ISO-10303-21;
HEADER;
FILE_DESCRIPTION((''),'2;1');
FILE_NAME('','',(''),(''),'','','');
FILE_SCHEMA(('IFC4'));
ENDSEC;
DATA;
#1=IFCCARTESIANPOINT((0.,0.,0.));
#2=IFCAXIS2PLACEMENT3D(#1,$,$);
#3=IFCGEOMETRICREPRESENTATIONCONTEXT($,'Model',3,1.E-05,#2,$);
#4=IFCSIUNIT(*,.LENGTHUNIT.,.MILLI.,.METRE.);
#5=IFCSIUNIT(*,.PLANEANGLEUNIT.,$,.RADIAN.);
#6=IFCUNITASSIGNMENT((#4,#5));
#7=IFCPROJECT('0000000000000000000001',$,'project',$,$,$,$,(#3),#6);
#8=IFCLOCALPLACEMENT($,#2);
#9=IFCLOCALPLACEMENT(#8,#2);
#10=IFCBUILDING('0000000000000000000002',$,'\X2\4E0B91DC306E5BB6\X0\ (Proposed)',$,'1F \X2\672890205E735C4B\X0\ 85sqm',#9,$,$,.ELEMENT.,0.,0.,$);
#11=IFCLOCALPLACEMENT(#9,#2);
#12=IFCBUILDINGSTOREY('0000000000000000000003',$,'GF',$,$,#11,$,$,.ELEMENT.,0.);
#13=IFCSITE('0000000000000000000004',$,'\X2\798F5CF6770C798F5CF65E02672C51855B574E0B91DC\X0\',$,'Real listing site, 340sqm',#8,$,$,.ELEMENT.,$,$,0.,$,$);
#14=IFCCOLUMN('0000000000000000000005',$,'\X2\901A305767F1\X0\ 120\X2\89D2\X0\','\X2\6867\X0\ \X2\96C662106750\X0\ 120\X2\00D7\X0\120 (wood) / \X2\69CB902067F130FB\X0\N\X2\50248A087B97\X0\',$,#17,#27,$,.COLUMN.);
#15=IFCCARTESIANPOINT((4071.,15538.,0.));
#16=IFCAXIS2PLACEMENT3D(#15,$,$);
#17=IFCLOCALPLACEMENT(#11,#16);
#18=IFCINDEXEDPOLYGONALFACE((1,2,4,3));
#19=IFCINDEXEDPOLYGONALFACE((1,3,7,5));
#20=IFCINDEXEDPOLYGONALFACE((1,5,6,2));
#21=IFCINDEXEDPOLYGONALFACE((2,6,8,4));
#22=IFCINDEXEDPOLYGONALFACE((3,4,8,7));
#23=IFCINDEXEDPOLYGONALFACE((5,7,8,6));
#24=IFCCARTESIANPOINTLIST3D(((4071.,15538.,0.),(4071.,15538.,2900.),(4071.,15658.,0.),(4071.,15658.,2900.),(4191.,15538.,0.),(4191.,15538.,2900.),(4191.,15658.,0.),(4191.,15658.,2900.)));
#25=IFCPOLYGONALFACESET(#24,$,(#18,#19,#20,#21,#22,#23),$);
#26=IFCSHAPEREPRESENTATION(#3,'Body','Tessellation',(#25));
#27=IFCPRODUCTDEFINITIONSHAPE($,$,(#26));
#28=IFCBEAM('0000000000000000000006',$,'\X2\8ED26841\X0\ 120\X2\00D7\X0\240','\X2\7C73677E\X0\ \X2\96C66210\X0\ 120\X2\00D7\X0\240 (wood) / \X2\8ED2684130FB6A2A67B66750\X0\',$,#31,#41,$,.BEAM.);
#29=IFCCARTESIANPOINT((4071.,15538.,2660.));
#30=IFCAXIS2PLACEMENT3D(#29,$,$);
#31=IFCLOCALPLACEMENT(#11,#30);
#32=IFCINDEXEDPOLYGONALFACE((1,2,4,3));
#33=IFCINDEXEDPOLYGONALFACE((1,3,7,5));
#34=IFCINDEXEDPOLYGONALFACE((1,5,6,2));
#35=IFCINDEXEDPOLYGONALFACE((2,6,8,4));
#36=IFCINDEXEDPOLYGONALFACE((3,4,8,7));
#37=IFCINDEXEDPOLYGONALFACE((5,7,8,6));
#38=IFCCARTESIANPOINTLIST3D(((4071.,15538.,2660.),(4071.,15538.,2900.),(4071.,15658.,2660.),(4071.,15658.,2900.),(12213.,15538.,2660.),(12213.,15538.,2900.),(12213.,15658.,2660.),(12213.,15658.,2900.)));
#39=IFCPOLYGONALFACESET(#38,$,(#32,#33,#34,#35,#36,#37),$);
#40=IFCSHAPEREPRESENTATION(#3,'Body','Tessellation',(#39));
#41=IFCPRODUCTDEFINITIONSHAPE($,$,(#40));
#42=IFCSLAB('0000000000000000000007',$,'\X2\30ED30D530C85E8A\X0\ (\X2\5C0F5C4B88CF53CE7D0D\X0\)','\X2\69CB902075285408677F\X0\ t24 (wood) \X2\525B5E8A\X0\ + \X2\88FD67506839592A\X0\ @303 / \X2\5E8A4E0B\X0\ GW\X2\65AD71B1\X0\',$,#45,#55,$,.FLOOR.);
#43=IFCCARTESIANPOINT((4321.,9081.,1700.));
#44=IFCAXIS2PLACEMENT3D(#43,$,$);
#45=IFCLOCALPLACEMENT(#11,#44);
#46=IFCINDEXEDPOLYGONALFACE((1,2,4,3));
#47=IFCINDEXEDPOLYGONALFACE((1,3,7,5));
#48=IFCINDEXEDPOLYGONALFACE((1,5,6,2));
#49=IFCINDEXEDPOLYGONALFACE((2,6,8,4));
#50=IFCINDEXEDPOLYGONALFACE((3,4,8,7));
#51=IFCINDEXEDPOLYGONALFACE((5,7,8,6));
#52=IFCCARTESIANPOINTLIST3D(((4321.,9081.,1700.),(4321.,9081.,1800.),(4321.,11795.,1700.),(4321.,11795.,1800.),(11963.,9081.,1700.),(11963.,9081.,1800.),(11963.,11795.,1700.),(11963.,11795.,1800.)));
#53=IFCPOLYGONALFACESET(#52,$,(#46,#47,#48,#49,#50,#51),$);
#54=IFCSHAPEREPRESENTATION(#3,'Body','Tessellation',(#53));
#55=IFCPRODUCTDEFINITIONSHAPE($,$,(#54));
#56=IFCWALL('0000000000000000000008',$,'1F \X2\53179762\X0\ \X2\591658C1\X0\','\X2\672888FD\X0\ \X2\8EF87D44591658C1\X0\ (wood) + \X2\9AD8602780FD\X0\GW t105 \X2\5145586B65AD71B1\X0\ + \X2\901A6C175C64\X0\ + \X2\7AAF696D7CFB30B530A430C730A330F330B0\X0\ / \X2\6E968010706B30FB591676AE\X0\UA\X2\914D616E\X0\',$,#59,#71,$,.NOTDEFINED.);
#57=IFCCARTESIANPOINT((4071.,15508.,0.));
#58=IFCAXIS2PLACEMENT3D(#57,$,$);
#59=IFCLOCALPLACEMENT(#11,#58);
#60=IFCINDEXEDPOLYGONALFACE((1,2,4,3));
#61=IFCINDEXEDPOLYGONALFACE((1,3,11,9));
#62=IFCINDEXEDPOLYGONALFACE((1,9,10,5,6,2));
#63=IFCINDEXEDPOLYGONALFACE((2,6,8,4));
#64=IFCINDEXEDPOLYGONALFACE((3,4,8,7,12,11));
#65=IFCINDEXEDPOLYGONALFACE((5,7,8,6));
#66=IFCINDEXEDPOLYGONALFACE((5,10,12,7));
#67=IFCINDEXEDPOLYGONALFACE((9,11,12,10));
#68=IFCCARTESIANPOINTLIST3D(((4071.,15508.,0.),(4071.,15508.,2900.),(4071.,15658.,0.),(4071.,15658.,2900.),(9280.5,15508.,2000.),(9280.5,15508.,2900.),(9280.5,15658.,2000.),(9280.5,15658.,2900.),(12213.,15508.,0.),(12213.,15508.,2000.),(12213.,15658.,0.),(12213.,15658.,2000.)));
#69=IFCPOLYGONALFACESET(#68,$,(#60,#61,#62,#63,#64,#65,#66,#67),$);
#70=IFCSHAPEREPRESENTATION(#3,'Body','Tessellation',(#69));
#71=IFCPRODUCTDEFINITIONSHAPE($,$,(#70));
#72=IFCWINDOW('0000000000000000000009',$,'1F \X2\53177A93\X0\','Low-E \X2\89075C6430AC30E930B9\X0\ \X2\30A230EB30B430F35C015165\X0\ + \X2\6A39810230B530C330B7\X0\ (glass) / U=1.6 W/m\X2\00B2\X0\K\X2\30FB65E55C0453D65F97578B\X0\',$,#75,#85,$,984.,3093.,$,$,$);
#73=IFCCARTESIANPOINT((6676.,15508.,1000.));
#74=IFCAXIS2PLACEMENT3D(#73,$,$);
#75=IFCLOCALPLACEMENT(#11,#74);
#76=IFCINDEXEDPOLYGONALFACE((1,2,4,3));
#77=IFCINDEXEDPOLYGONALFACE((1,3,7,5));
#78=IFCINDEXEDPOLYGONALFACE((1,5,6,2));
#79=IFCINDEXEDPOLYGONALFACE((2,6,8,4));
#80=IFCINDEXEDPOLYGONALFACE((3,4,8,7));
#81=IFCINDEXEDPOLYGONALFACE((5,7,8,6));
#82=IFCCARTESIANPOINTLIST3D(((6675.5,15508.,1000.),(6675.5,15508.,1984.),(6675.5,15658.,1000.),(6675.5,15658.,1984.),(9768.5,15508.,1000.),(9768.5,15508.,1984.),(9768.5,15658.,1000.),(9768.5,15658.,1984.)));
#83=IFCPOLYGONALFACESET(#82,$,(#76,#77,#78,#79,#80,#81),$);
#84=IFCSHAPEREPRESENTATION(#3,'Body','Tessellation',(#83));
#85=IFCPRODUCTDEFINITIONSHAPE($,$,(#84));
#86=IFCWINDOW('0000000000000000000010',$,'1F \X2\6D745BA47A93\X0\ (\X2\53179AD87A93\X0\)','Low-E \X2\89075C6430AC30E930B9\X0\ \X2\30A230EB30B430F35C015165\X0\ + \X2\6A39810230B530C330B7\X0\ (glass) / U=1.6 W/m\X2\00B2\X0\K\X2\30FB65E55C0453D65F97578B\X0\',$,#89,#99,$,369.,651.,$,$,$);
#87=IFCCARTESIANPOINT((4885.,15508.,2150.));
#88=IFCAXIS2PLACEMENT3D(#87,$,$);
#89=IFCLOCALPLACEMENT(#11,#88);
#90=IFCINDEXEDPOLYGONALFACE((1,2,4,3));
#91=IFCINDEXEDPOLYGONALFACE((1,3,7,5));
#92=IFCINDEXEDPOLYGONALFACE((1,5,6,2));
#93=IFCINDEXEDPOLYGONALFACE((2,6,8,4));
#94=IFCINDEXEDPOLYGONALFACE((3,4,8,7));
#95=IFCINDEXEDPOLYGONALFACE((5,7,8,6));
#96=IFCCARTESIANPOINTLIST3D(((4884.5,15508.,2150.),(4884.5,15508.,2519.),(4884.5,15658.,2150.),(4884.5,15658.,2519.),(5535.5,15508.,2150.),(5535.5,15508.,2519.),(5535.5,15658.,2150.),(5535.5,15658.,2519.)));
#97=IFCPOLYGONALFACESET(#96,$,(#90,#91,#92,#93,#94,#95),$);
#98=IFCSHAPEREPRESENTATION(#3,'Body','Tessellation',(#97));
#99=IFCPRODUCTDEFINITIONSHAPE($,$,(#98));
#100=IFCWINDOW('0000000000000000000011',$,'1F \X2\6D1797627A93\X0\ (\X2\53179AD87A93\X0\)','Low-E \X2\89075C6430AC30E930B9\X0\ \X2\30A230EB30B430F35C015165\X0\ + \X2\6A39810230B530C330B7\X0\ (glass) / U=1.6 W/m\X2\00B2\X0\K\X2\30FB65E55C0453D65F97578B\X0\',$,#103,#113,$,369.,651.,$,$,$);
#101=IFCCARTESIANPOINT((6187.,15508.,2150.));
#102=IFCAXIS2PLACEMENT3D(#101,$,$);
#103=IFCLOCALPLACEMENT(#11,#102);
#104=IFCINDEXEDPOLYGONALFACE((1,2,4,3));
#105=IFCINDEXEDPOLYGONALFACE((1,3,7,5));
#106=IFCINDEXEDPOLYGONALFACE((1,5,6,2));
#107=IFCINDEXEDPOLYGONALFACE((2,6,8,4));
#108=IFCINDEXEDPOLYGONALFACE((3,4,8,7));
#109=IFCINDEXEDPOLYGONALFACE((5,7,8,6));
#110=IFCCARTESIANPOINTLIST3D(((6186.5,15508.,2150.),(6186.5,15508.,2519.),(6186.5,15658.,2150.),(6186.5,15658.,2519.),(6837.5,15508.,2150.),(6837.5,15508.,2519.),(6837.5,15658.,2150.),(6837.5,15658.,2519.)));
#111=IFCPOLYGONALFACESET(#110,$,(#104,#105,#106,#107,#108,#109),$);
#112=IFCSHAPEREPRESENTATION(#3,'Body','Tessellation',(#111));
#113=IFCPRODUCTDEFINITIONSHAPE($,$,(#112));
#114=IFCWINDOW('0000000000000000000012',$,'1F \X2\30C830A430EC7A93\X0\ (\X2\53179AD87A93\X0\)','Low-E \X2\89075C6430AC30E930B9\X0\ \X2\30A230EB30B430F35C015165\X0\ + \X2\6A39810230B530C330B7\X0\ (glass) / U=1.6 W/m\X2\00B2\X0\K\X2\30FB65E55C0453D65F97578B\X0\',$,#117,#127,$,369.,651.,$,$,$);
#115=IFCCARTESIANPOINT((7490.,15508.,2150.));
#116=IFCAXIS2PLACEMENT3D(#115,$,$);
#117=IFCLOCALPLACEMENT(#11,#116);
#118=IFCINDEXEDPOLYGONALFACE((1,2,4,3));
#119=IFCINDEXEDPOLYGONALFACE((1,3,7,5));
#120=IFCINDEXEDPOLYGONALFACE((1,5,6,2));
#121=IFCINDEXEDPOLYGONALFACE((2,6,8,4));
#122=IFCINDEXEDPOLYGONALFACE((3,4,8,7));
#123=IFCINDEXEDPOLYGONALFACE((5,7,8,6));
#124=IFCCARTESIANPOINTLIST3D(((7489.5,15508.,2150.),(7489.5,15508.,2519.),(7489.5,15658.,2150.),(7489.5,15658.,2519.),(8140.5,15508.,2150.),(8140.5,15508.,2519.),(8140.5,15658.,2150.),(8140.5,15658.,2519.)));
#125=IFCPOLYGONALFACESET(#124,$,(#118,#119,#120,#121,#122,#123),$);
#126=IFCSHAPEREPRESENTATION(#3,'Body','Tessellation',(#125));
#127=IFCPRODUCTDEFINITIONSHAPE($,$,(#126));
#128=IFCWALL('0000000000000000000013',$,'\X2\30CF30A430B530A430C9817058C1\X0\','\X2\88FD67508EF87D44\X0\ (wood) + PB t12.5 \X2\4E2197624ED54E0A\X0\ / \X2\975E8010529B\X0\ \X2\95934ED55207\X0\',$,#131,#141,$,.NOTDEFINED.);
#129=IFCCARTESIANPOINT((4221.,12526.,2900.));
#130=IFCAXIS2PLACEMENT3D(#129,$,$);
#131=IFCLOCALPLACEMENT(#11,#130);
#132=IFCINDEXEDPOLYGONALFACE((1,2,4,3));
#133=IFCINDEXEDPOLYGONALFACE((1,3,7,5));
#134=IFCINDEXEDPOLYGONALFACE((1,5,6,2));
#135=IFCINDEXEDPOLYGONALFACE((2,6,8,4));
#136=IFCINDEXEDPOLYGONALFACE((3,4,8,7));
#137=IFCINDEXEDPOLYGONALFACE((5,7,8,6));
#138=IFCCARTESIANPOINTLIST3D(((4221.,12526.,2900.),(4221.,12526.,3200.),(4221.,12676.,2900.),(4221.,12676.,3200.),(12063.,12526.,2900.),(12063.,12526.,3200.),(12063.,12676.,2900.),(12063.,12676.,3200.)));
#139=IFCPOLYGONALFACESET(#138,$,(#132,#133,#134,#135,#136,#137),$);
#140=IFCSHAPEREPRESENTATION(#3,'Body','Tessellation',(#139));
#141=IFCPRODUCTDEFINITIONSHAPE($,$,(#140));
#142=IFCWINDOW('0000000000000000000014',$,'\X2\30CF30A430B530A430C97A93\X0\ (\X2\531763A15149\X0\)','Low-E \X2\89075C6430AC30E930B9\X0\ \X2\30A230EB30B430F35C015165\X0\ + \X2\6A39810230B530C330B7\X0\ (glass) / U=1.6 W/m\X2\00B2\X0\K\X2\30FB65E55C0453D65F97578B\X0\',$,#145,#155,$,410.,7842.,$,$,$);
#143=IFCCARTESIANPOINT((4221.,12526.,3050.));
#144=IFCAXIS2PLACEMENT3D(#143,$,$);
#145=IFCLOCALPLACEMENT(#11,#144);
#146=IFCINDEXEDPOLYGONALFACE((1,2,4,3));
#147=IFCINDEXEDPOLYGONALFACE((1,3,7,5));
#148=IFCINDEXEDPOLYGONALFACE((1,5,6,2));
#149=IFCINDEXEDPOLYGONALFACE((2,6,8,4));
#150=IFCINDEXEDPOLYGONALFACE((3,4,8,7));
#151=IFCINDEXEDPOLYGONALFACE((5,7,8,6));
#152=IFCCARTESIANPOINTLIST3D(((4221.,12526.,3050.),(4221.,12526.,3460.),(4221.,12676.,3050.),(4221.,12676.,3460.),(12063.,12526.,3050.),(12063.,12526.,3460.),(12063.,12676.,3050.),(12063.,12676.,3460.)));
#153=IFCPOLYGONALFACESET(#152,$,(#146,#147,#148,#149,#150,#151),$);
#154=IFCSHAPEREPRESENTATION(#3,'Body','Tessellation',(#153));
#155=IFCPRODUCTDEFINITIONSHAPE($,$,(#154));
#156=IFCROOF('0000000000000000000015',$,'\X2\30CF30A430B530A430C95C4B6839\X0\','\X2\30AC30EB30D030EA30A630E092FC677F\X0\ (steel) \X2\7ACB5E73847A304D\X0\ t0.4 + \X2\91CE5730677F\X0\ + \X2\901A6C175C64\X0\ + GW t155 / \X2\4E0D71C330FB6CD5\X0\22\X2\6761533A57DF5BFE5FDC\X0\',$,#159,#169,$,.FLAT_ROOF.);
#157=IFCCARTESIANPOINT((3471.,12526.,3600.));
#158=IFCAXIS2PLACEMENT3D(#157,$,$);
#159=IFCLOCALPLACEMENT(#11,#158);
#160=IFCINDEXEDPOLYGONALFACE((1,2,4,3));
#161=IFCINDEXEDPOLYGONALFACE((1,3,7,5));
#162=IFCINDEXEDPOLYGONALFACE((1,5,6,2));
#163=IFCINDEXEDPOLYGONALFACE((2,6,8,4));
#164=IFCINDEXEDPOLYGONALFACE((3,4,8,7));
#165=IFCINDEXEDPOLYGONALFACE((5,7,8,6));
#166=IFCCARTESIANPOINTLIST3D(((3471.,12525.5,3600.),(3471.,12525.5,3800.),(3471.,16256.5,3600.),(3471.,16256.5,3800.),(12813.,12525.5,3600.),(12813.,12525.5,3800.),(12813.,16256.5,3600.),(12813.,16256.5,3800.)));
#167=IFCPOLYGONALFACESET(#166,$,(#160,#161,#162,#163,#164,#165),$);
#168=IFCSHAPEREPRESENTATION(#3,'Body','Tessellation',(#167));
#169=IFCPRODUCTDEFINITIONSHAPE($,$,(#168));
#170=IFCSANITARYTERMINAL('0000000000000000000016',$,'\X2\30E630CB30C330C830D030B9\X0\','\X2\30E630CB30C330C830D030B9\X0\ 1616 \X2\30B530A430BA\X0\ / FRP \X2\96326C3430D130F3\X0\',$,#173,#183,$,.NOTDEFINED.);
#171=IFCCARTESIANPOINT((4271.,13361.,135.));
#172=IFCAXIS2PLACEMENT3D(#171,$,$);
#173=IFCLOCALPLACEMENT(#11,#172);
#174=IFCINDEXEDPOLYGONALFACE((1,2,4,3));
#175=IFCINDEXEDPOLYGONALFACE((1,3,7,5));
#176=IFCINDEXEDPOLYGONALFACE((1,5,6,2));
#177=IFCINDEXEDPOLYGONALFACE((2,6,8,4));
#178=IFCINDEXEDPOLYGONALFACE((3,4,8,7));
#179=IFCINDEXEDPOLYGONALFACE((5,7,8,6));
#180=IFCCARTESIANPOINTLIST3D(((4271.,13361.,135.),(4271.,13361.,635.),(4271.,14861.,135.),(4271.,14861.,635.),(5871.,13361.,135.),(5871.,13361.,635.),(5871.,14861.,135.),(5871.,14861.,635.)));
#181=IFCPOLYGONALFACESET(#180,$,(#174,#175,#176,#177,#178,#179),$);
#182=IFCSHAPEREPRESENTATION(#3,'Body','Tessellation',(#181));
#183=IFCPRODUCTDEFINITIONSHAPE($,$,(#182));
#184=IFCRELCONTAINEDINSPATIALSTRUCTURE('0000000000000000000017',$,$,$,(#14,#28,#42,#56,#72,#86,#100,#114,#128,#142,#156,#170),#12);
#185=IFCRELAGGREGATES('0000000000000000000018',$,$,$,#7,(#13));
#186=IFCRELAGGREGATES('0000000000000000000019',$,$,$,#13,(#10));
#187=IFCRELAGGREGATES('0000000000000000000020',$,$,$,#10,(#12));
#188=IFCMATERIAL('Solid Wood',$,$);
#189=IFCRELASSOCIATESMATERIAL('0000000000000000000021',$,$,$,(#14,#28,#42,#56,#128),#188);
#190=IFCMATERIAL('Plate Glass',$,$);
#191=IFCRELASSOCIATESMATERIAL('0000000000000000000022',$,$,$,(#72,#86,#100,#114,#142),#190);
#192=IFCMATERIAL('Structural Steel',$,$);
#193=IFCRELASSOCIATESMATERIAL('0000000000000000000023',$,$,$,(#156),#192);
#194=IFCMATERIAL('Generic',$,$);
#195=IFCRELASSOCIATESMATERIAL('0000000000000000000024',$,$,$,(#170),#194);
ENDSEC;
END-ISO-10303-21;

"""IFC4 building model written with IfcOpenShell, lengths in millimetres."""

from ifc_helpers import new_model, si_unit, frame, frame_2d, origin, place, context, project, spatial, rectangle, extrude, material, element, fill, save


model = new_model("IFC4")

# Units and contexts
model_context = context("Model", 3, precision=1e-05, world=origin())
ifc_project = project(units=[si_unit("LENGTHUNIT", "METRE", prefix="MILLI"), si_unit("PLANEANGLEUNIT", "RADIAN")], contexts=[model_context])

# Site, building, storey
site_placement = place(None, origin())
site = spatial("IfcSite", under=ifc_project, at=site_placement, Name="福島県福島市本内字下釜", ObjectType="Real listing site, 340sqm", CompositionType="ELEMENT", RefElevation=0.0)
building_placement = place(site_placement, origin())
building = spatial("IfcBuilding", under=site, at=building_placement, Name="下釜の家 (Proposed)", ObjectType="1F 木造平屋 85sqm", CompositionType="ELEMENT", ElevationOfRefHeight=0.0, ElevationOfTerrain=0.0)
storey_placement = place(building_placement, origin())
storey = spatial("IfcBuildingStorey", under=building, at=storey_placement, Name="GF", CompositionType="ELEMENT", Elevation=0.0)

# Column
ifc_material_1 = material(Name="Solid Wood")
column_1_placement = place(storey_placement, frame((4071.0, 15538.0, 0.0)))
element("IfcColumn", 1, at=column_1_placement, inside=storey, material=ifc_material_1, Name="通し柱 120角", Description="桧 集成材 120×120 (wood) / 構造柱・N値計算", PredefinedType="COLUMN", context=model_context, shape_type="SweptSolid", body=[
    extrude(rectangle(XDim=120.0, YDim=120.0, at=frame_2d((60.0, 60.0))), frame((4071.0, 15538.0, 0.0)), (0.0, 0.0, 1.0), 2900.0),
])

# Beam
beam_1_placement = place(storey_placement, frame((4071.0, 15538.0, 2660.0)))
element("IfcBeam", 2, at=beam_1_placement, inside=storey, material=ifc_material_1, Name="軒桁 120×240", Description="米松 集成 120×240 (wood) / 軒桁・横架材", PredefinedType="BEAM", context=model_context, shape_type="SweptSolid", body=[
    extrude(rectangle(XDim=8142.0, YDim=120.0, at=frame_2d((4071.0, 60.0))), frame((4071.0, 15538.0, 2660.0)), (0.0, 0.0, 1.0), 240.0),
])

# Slab
slab_placement = place(storey_placement, frame((4321.0, 9081.0, 1700.0)))
element("IfcSlab", 3, at=slab_placement, inside=storey, material=ifc_material_1, Name="ロフト床 (小屋裏収納)", Description="構造用合板 t24 (wood) 剛床 + 製材根太 @303 / 床下 GW断熱", PredefinedType="FLOOR", context=model_context, shape_type="SweptSolid", body=[
    extrude(rectangle(XDim=7642.0, YDim=2714.0, at=frame_2d((3821.0, 1357.0))), frame((4321.0, 9081.0, 1700.0)), (0.0, 0.0, 1.0), 100.0),
])

# Wall, openings, windows
wall_1_placement = place(storey_placement, frame((4071.0, 15508.0, 0.0)))
wall_1 = element("IfcWall", 4, at=wall_1_placement, inside=storey, material=ifc_material_1, Name="1F 北面 外壁", Description="木製 軸組外壁 (wood) + 高性能GW t105 充填断熱 + 通気層 + 窯業系サイディング / 準耐火・外皮UA配慮", PredefinedType="NOTDEFINED", context=model_context, shape_type="SweptSolid", body=[
    extrude(rectangle(XDim=8142.0, YDim=150.0, at=frame_2d((4071.0, 75.0))), frame((4071.0, 15508.0, 0.0)), (0.0, 0.0, 1.0), 2900.0),
])
opening_1_placement = place(storey_placement, frame((6676.0, 15508.0, 1000.0)))
opening_1 = element("IfcOpeningElement", 5, at=opening_1_placement, cuts=wall_1, PredefinedType="NOTDEFINED", context=model_context, shape_type="SweptSolid", body=[
    extrude(rectangle(XDim=3093.0, YDim=150.0, at=frame_2d((1546.0, 75.0))), frame((6676.0, 15508.0, 1000.0)), (0.0, 0.0, 1.0), 984.0),
])
opening_2_placement = place(storey_placement, frame((4885.0, 15508.0, 2150.0)))
opening_2 = element("IfcOpeningElement", 6, at=opening_2_placement, cuts=wall_1, PredefinedType="NOTDEFINED", context=model_context, shape_type="SweptSolid", body=[
    extrude(rectangle(XDim=651.0, YDim=150.0, at=frame_2d((325.0, 75.0))), frame((4885.0, 15508.0, 2150.0)), (0.0, 0.0, 1.0), 369.0),
])
opening_3_placement = place(storey_placement, frame((6187.0, 15508.0, 2150.0)))
opening_3 = element("IfcOpeningElement", 7, at=opening_3_placement, cuts=wall_1, PredefinedType="NOTDEFINED", context=model_context, shape_type="SweptSolid", body=[
    extrude(rectangle(XDim=651.0, YDim=150.0, at=frame_2d((325.0, 75.0))), frame((6187.0, 15508.0, 2150.0)), (0.0, 0.0, 1.0), 369.0),
])
opening_4_placement = place(storey_placement, frame((7490.0, 15508.0, 2150.0)))
opening_4 = element("IfcOpeningElement", 8, at=opening_4_placement, cuts=wall_1, PredefinedType="NOTDEFINED", context=model_context, shape_type="SweptSolid", body=[
    extrude(rectangle(XDim=651.0, YDim=150.0, at=frame_2d((325.0, 75.0))), frame((7490.0, 15508.0, 2150.0)), (0.0, 0.0, 1.0), 369.0),
])
ifc_material_2 = material(Name="Plate Glass")
window_1_placement = place(storey_placement, frame((6676.0, 15508.0, 1000.0)))
window_1 = element("IfcWindow", 9, at=window_1_placement, inside=storey, material=ifc_material_2, Name="1F 北窓", Description="Low-E 複層ガラス アルゴン封入 + 樹脂サッシ (glass) / U=1.6 W/m²K・日射取得型", OverallHeight=984.0, OverallWidth=3093.0, context=model_context, shape_type="SweptSolid", body=[
    extrude(rectangle(XDim=3093.0, YDim=150.0, at=frame_2d((1546.0, 75.0))), frame((6676.0, 15508.0, 1000.0)), (0.0, 0.0, 1.0), 984.0),
])
fill(opening_1, window_1)
window_2_placement = place(storey_placement, frame((4885.0, 15508.0, 2150.0)))
window_2 = element("IfcWindow", 10, at=window_2_placement, inside=storey, material=ifc_material_2, Name="1F 浴室窓 (北高窓)", Description="Low-E 複層ガラス アルゴン封入 + 樹脂サッシ (glass) / U=1.6 W/m²K・日射取得型", OverallHeight=369.0, OverallWidth=651.0, context=model_context, shape_type="SweptSolid", body=[
    extrude(rectangle(XDim=651.0, YDim=150.0, at=frame_2d((325.0, 75.0))), frame((4885.0, 15508.0, 2150.0)), (0.0, 0.0, 1.0), 369.0),
])
fill(opening_2, window_2)
window_3_placement = place(storey_placement, frame((6187.0, 15508.0, 2150.0)))
window_3 = element("IfcWindow", 11, at=window_3_placement, inside=storey, material=ifc_material_2, Name="1F 洗面窓 (北高窓)", Description="Low-E 複層ガラス アルゴン封入 + 樹脂サッシ (glass) / U=1.6 W/m²K・日射取得型", OverallHeight=369.0, OverallWidth=651.0, context=model_context, shape_type="SweptSolid", body=[
    extrude(rectangle(XDim=651.0, YDim=150.0, at=frame_2d((325.0, 75.0))), frame((6187.0, 15508.0, 2150.0)), (0.0, 0.0, 1.0), 369.0),
])
fill(opening_3, window_3)
window_4_placement = place(storey_placement, frame((7490.0, 15508.0, 2150.0)))
window_4 = element("IfcWindow", 12, at=window_4_placement, inside=storey, material=ifc_material_2, Name="1F トイレ窓 (北高窓)", Description="Low-E 複層ガラス アルゴン封入 + 樹脂サッシ (glass) / U=1.6 W/m²K・日射取得型", OverallHeight=369.0, OverallWidth=651.0, context=model_context, shape_type="SweptSolid", body=[
    extrude(rectangle(XDim=651.0, YDim=150.0, at=frame_2d((325.0, 75.0))), frame((7490.0, 15508.0, 2150.0)), (0.0, 0.0, 1.0), 369.0),
])
fill(opening_4, window_4)

# Wall, opening, window
wall_2_placement = place(storey_placement, frame((4221.0, 12526.0, 2900.0)))
wall_2 = element("IfcWall", 13, at=wall_2_placement, inside=storey, material=ifc_material_1, Name="ハイサイド腰壁", Description="製材軸組 (wood) + PB t12.5 両面仕上 / 非耐力 間仕切", PredefinedType="NOTDEFINED", context=model_context, shape_type="SweptSolid", body=[
    extrude(rectangle(XDim=7842.0, YDim=150.0, at=frame_2d((3921.0, 75.0))), frame((4221.0, 12526.0, 2900.0)), (0.0, 0.0, 1.0), 700.0),
])
opening_5_placement = place(storey_placement, frame((4221.0, 12526.0, 3050.0)))
opening_5 = element("IfcOpeningElement", 14, at=opening_5_placement, cuts=wall_2, PredefinedType="NOTDEFINED", context=model_context, shape_type="SweptSolid", body=[
    extrude(rectangle(XDim=7842.0, YDim=150.0, at=frame_2d((3921.0, 75.0))), frame((4221.0, 12526.0, 3050.0)), (0.0, 0.0, 1.0), 410.0),
])
window_5_placement = place(storey_placement, frame((4221.0, 12526.0, 3050.0)))
window_5 = element("IfcWindow", 15, at=window_5_placement, inside=storey, material=ifc_material_2, Name="ハイサイド窓 (北採光)", Description="Low-E 複層ガラス アルゴン封入 + 樹脂サッシ (glass) / U=1.6 W/m²K・日射取得型", OverallHeight=410.0, OverallWidth=7842.0, context=model_context, shape_type="SweptSolid", body=[
    extrude(rectangle(XDim=7842.0, YDim=150.0, at=frame_2d((3921.0, 75.0))), frame((4221.0, 12526.0, 3050.0)), (0.0, 0.0, 1.0), 410.0),
])
fill(opening_5, window_5)

# Roof
ifc_material_3 = material(Name="Structural Steel")
roof_placement = place(storey_placement, frame((3471.0, 12526.0, 3600.0)))
element("IfcRoof", 16, at=roof_placement, inside=storey, material=ifc_material_3, Name="ハイサイド屋根", Description="ガルバリウム鋼板 (steel) 立平葺き t0.4 + 野地板 + 通気層 + GW t155 / 不燃・法22条区域対応", PredefinedType="FLAT_ROOF", context=model_context, shape_type="SweptSolid", body=[
    extrude(rectangle(XDim=9342.0, YDim=3731.0, at=frame_2d((4671.0, 1865.0))), frame((3471.0, 12526.0, 3600.0)), (0.0, 0.0, 1.0), 200.0),
])

# Sanitary terminal
ifc_material_4 = material(Name="Generic")
sanitary_terminal_placement = place(storey_placement, frame((4271.0, 13361.0, 135.0)))
element("IfcSanitaryTerminal", 17, at=sanitary_terminal_placement, inside=storey, material=ifc_material_4, Name="ユニットバス", Description="ユニットバス 1616 サイズ / FRP 防水パン", PredefinedType="NOTDEFINED", context=model_context, shape_type="SweptSolid", body=[
    extrude(rectangle(XDim=1600.0, YDim=1500.0, at=frame_2d((800.0, 750.0))), frame((4271.0, 13361.0, 135.0)), (0.0, 0.0, 1.0), 500.0),
])

save(model, "model.ifc")
